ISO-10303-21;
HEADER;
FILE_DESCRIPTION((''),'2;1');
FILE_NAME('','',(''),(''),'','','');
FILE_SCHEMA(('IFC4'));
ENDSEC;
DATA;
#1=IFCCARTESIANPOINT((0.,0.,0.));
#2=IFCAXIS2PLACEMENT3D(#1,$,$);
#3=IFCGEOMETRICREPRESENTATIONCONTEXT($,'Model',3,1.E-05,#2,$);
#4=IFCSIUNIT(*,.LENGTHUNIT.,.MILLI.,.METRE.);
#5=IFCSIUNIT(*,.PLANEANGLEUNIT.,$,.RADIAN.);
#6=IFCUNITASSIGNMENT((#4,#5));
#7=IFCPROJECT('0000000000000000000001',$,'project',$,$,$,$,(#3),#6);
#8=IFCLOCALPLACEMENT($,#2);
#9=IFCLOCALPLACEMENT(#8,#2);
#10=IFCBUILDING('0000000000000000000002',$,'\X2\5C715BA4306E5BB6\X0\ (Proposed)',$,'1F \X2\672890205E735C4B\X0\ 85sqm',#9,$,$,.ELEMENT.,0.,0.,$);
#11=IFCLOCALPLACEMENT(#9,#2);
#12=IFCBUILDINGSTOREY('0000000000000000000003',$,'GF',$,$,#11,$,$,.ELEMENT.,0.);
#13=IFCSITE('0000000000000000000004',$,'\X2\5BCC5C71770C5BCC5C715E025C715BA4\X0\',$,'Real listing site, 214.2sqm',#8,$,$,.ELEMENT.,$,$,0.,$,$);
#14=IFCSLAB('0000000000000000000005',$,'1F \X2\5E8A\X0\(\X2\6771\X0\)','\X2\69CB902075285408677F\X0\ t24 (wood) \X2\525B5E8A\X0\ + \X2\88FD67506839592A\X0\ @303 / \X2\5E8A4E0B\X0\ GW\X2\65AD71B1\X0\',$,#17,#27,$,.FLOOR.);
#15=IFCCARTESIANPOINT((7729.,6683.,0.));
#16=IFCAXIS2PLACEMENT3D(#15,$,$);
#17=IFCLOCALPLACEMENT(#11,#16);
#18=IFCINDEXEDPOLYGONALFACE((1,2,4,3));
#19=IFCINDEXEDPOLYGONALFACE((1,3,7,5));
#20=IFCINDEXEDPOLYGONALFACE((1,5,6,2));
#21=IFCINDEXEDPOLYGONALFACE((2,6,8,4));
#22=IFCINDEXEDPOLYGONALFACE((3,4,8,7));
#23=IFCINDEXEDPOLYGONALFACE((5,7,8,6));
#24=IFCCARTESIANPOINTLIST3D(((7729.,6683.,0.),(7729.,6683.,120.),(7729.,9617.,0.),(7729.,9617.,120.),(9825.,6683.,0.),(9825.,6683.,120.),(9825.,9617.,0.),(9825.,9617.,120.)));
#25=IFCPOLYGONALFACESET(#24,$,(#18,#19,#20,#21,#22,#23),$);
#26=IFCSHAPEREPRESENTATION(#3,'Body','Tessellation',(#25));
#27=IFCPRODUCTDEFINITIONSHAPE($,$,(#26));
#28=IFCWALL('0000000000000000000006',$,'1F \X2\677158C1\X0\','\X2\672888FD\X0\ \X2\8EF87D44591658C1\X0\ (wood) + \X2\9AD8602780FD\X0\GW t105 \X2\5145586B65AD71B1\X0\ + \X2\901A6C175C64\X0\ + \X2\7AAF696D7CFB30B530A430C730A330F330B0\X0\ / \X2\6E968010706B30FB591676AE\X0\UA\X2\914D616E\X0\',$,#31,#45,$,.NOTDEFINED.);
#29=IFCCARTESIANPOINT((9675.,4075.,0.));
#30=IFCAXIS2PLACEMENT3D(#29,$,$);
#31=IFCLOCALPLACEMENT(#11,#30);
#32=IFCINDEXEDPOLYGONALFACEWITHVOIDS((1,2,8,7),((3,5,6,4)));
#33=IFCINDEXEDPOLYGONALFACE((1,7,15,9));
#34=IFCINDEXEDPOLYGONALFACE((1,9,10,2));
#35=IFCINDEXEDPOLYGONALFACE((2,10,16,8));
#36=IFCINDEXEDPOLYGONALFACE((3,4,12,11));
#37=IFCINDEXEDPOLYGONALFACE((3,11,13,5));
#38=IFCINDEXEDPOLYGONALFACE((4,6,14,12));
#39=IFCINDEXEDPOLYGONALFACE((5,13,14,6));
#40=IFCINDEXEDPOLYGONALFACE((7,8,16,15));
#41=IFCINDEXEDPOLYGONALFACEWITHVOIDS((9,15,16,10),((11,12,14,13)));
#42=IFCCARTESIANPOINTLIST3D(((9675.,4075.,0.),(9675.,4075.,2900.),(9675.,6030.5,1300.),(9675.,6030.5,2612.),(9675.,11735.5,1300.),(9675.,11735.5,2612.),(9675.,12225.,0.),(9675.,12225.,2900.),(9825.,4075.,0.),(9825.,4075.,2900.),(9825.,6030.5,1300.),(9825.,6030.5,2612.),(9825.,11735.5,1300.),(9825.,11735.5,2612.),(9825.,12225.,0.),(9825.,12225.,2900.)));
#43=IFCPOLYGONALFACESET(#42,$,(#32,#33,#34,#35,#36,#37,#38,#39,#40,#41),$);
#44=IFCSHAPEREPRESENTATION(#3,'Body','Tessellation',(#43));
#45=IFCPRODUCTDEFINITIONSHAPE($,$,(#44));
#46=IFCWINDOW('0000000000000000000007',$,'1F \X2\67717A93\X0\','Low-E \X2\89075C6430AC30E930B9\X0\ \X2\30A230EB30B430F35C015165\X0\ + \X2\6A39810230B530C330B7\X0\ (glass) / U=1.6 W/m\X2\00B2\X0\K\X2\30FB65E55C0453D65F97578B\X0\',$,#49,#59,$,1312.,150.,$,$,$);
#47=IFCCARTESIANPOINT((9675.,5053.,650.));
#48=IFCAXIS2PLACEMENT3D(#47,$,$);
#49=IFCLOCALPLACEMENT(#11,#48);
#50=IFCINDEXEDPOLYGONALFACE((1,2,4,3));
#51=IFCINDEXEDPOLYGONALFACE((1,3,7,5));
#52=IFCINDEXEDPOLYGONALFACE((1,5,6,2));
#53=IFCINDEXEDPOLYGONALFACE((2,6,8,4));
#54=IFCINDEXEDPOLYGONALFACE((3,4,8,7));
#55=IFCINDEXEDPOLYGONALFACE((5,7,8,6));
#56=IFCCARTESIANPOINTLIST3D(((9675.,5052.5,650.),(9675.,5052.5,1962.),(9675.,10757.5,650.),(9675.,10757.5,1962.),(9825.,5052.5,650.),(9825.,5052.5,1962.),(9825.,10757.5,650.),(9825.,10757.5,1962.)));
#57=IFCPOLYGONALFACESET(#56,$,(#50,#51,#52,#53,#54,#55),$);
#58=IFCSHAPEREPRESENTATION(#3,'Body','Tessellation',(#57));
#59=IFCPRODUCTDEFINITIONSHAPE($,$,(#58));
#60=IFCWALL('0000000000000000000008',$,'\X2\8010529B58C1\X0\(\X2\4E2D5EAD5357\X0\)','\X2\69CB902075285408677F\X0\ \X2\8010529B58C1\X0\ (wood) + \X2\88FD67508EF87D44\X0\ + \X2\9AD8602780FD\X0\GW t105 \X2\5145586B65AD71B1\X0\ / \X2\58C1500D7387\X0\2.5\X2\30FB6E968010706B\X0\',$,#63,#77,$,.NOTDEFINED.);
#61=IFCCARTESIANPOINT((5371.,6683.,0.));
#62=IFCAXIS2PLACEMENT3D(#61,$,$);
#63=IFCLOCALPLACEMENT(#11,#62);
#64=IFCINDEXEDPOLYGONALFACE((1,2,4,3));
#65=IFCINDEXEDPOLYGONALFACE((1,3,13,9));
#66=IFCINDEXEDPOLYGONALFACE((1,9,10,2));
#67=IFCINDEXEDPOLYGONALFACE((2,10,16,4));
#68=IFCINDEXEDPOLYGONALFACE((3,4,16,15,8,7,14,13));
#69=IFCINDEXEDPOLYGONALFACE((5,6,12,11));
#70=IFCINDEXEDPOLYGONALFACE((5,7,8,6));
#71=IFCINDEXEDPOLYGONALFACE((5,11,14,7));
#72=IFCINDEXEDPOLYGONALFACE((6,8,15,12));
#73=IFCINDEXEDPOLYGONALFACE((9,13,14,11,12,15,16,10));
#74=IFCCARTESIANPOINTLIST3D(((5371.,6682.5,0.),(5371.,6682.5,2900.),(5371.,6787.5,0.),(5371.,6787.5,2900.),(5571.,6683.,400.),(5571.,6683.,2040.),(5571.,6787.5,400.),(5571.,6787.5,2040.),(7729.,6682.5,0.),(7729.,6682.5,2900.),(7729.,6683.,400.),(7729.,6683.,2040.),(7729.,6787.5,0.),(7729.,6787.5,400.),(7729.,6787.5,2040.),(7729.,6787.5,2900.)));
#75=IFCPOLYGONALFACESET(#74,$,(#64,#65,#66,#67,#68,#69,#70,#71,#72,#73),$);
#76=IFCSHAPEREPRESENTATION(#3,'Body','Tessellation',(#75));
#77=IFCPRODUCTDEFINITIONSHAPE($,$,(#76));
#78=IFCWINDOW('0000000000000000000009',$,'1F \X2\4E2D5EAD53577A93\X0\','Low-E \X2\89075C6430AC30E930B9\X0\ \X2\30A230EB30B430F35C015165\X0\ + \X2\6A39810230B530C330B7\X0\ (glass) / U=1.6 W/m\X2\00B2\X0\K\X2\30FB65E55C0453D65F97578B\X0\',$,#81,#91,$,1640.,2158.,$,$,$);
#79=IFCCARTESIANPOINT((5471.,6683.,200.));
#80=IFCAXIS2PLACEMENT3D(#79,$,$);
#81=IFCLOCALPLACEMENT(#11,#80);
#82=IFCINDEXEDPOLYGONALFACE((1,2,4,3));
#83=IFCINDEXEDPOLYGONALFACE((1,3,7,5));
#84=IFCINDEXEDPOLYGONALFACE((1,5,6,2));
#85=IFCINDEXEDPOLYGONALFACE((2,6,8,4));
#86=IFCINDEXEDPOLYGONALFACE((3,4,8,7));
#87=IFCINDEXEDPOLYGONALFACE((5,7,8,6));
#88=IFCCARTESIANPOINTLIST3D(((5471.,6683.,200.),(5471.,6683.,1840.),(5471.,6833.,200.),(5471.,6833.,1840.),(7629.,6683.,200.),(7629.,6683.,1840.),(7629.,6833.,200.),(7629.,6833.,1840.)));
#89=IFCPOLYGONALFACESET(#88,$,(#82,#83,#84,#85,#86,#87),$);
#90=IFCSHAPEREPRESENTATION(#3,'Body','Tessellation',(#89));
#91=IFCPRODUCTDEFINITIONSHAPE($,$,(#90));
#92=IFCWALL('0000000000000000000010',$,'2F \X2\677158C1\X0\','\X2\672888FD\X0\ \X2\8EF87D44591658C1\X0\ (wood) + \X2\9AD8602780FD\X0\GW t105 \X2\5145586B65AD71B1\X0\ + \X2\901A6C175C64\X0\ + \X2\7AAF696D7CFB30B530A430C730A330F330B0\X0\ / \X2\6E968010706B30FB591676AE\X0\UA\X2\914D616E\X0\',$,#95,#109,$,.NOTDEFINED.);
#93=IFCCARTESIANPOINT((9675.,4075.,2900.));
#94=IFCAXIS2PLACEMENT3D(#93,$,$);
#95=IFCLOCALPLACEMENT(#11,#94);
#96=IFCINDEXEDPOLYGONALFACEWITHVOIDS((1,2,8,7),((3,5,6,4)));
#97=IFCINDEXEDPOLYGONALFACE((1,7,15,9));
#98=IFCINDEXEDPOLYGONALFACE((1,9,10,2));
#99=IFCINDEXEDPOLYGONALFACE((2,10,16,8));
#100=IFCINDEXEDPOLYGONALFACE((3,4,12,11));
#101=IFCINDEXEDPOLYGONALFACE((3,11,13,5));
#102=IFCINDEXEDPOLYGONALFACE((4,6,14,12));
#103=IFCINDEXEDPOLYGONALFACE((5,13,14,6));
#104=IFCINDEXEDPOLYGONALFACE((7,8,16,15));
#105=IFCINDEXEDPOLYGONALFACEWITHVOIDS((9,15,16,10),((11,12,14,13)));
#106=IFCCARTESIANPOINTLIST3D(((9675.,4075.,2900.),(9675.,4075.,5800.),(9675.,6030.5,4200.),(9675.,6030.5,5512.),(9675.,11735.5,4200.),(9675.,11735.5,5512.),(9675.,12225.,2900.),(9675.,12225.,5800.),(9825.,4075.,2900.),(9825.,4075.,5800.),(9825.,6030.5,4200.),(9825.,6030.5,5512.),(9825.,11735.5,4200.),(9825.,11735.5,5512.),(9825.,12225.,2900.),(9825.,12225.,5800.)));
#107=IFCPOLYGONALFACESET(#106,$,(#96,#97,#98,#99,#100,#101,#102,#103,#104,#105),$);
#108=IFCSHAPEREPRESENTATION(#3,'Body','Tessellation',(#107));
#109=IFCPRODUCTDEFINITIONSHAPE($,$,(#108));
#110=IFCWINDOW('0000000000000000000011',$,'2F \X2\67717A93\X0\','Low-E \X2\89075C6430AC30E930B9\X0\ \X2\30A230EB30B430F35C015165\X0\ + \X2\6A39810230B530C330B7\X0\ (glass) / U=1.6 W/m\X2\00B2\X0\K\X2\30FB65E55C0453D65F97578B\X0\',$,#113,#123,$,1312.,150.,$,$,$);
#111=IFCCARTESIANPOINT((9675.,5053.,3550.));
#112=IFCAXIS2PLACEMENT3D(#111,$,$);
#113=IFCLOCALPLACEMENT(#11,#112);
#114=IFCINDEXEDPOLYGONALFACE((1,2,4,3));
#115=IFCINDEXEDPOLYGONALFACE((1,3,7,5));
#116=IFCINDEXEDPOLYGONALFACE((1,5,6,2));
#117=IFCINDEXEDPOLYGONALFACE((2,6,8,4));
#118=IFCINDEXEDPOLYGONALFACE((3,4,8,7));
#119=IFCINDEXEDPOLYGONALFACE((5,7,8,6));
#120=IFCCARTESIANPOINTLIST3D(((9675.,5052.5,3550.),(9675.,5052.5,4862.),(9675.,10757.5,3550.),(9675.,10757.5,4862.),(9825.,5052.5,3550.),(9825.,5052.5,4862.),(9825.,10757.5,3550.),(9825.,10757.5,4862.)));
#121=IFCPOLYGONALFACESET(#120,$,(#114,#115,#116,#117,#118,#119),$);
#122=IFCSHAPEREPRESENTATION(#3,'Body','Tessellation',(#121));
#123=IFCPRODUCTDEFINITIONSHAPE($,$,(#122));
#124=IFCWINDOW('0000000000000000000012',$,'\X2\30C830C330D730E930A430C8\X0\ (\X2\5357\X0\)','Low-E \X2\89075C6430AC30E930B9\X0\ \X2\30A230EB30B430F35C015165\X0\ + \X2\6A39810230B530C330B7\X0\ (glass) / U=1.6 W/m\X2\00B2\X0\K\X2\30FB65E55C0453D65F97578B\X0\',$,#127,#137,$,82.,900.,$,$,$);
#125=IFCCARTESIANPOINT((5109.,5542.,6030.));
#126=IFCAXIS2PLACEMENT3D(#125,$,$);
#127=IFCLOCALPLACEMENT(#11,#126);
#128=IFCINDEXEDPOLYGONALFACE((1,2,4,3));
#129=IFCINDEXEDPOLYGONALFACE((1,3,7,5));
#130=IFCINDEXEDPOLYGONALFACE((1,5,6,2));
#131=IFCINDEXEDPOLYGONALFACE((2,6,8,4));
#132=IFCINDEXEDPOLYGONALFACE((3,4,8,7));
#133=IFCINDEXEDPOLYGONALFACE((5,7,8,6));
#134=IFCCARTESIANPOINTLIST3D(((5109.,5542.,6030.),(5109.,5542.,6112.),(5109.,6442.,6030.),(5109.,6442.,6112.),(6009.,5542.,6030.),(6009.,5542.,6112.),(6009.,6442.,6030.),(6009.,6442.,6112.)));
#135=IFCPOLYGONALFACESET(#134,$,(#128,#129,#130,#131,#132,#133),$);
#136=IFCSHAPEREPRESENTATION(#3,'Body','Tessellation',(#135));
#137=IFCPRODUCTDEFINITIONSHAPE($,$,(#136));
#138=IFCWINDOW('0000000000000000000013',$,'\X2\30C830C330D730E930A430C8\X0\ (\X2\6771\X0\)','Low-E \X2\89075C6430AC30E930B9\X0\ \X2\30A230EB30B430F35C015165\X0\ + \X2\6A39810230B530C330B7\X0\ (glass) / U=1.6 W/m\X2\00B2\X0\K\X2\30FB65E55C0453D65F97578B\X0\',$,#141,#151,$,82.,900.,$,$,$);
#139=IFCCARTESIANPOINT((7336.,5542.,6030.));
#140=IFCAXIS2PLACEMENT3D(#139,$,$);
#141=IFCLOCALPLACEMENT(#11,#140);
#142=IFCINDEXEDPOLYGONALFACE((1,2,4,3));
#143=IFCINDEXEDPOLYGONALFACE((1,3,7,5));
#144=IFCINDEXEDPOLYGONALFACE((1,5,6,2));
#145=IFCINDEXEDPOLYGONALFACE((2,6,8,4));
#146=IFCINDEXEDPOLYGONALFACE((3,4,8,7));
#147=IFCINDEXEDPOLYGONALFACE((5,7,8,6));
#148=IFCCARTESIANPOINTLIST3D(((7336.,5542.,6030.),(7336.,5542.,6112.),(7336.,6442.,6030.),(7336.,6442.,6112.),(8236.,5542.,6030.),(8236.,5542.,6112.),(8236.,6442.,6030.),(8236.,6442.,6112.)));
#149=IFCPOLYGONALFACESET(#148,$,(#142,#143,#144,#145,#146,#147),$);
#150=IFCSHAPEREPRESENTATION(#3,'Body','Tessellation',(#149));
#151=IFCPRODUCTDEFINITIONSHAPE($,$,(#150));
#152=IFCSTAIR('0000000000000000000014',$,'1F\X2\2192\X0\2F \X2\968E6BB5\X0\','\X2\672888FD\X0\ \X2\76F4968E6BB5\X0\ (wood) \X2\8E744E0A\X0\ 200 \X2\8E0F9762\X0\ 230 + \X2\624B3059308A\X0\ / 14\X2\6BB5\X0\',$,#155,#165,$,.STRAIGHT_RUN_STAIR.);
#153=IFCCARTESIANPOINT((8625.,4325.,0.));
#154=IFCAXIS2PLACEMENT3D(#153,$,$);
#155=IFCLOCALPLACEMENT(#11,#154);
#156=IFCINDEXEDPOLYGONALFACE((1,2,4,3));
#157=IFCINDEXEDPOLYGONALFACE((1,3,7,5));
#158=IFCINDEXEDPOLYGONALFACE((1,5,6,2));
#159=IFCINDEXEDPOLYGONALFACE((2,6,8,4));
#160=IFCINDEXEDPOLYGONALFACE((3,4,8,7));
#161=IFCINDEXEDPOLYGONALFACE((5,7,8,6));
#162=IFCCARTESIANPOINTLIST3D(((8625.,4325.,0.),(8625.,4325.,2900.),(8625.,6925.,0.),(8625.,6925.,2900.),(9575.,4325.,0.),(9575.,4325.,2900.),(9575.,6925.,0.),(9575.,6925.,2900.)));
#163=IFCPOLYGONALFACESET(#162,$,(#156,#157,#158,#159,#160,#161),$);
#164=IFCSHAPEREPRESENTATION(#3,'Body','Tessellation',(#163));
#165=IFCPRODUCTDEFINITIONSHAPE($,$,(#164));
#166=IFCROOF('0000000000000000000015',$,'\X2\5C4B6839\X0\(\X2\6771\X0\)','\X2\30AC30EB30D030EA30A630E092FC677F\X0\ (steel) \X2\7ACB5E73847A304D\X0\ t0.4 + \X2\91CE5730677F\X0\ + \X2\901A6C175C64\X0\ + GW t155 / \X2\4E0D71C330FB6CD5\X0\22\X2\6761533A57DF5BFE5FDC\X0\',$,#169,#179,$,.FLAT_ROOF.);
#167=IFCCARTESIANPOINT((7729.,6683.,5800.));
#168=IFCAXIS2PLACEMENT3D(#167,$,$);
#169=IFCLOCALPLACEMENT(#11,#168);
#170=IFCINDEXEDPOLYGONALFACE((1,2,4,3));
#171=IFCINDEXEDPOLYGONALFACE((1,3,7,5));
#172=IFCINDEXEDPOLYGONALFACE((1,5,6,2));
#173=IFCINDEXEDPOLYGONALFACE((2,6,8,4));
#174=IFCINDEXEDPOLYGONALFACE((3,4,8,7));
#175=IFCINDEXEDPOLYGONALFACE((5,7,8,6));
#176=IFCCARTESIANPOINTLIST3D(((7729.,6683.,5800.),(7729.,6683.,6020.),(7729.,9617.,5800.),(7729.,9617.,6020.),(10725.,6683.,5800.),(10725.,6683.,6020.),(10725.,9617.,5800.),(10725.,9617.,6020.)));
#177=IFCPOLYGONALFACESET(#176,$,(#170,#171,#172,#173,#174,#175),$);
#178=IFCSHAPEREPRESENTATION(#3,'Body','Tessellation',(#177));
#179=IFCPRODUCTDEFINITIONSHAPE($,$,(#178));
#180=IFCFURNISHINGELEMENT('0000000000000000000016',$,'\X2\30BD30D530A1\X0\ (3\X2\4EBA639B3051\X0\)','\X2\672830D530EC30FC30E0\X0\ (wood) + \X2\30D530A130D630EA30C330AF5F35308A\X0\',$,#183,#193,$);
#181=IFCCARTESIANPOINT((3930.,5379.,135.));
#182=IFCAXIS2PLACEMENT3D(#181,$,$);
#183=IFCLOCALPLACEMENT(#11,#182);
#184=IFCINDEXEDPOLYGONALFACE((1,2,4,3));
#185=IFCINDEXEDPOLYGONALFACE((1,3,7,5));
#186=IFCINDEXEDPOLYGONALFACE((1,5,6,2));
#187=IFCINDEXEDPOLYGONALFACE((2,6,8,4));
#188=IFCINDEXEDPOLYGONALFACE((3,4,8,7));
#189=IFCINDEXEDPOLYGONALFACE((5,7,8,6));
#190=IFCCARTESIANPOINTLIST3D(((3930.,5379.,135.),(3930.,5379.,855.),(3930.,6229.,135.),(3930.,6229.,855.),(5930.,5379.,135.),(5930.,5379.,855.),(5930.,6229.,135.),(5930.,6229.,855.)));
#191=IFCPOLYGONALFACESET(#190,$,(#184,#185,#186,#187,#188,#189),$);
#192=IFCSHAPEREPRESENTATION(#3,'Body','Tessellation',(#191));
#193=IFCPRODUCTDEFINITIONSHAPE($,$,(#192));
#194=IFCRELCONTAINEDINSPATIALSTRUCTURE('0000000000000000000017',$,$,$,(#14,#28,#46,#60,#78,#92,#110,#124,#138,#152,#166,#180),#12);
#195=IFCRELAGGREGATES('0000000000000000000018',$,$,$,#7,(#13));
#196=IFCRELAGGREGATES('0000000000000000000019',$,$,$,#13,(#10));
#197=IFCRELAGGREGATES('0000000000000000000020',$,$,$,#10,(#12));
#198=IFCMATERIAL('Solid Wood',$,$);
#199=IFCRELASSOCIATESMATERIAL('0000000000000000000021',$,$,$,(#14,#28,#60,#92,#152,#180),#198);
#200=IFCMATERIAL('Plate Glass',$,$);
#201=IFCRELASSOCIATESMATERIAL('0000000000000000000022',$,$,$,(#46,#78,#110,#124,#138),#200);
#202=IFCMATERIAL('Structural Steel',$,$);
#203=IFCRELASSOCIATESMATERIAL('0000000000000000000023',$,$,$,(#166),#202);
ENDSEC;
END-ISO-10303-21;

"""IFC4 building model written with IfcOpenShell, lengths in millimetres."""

from ifc_helpers import new_model, si_unit, frame, frame_2d, origin, place, context, project, spatial, rectangle, extrude, material, element, fill, save


model = new_model("IFC4")

# Units and contexts
model_context = context("Model", 3, precision=1e-05, world=origin())
ifc_project = project(units=[si_unit("LENGTHUNIT", "METRE", prefix="MILLI"), si_unit("PLANEANGLEUNIT", "RADIAN")], contexts=[model_context])

# Site, building, storey
site_placement = place(None, origin())
site = spatial("IfcSite", under=ifc_project, at=site_placement, Name="富山県富山市山室", ObjectType="Real listing site, 214.2sqm", CompositionType="ELEMENT", RefElevation=0.0)
building_placement = place(site_placement, origin())
building = spatial("IfcBuilding", under=site, at=building_placement, Name="山室の家 (Proposed)", ObjectType="1F 木造平屋 85sqm", CompositionType="ELEMENT", ElevationOfRefHeight=0.0, ElevationOfTerrain=0.0)
storey_placement = place(building_placement, origin())
storey = spatial("IfcBuildingStorey", under=building, at=storey_placement, Name="GF", CompositionType="ELEMENT", Elevation=0.0)

# Slab
ifc_material_1 = material(Name="Solid Wood")
slab_placement = place(storey_placement, frame((7729.0, 6683.0, 0.0)))
element("IfcSlab", 1, at=slab_placement, inside=storey, material=ifc_material_1, Name="1F 床(東)", Description="構造用合板 t24 (wood) 剛床 + 製材根太 @303 / 床下 GW断熱", PredefinedType="FLOOR", context=model_context, shape_type="SweptSolid", body=[
    extrude(rectangle(XDim=2096.0, YDim=2934.0, at=frame_2d((1048.0, 1467.0))), frame((7729.0, 6683.0, 0.0)), (0.0, 0.0, 1.0), 120.0),
])

# Walls, openings, windows
wall_1_placement = place(storey_placement, frame((9675.0, 4075.0, 0.0)))
wall_1 = element("IfcWall", 2, at=wall_1_placement, inside=storey, material=ifc_material_1, Name="1F 東壁", Description="木製 軸組外壁 (wood) + 高性能GW t105 充填断熱 + 通気層 + 窯業系サイディング / 準耐火・外皮UA配慮", PredefinedType="NOTDEFINED", context=model_context, shape_type="SweptSolid", body=[
    extrude(rectangle(XDim=150.0, YDim=8150.0, at=frame_2d((75.0, 4075.0))), frame((9675.0, 4075.0, 0.0)), (0.0, 0.0, 1.0), 2900.0),
])
opening_1_placement = place(storey_placement, frame((9675.0, 5053.0, 650.0)))
opening_1 = element("IfcOpeningElement", 3, at=opening_1_placement, cuts=wall_1, PredefinedType="NOTDEFINED", context=model_context, shape_type="SweptSolid", body=[
    extrude(rectangle(XDim=150.0, YDim=5705.0, at=frame_2d((75.0, 2852.0))), frame((9675.0, 5053.0, 650.0)), (0.0, 0.0, 1.0), 1312.0),
])
ifc_material_2 = material(Name="Plate Glass")
window_1_placement = place(storey_placement, frame((9675.0, 5053.0, 650.0)))
window_1 = element("IfcWindow", 4, at=window_1_placement, inside=storey, material=ifc_material_2, Name="1F 東窓", Description="Low-E 複層ガラス アルゴン封入 + 樹脂サッシ (glass) / U=1.6 W/m²K・日射取得型", OverallHeight=1312.0, OverallWidth=150.0, context=model_context, shape_type="SweptSolid", body=[
    extrude(rectangle(XDim=150.0, YDim=5705.0, at=frame_2d((75.0, 2852.0))), frame((9675.0, 5053.0, 650.0)), (0.0, 0.0, 1.0), 1312.0),
])
fill(opening_1, window_1)
wall_2_placement = place(storey_placement, frame((5371.0, 6683.0, 0.0)))
wall_2 = element("IfcWall", 5, at=wall_2_placement, inside=storey, material=ifc_material_1, Name="耐力壁(中庭南)", Description="構造用合板 耐力壁 (wood) + 製材軸組 + 高性能GW t105 充填断熱 / 壁倍率2.5・準耐火", PredefinedType="NOTDEFINED", context=model_context, shape_type="SweptSolid", body=[
    extrude(rectangle(XDim=2358.0, YDim=105.0, at=frame_2d((1179.0, 52.0))), frame((5371.0, 6683.0, 0.0)), (0.0, 0.0, 1.0), 2900.0),
])
opening_2_placement = place(storey_placement, frame((5471.0, 6683.0, 200.0)))
opening_2 = element("IfcOpeningElement", 6, at=opening_2_placement, cuts=wall_2, PredefinedType="NOTDEFINED", context=model_context, shape_type="SweptSolid", body=[
    extrude(rectangle(XDim=2158.0, YDim=150.0, at=frame_2d((1079.0, 75.0))), frame((5471.0, 6683.0, 200.0)), (0.0, 0.0, 1.0), 1640.0),
])
window_2_placement = place(storey_placement, frame((5471.0, 6683.0, 200.0)))
window_2 = element("IfcWindow", 7, at=window_2_placement, inside=storey, material=ifc_material_2, Name="1F 中庭南窓", Description="Low-E 複層ガラス アルゴン封入 + 樹脂サッシ (glass) / U=1.6 W/m²K・日射取得型", OverallHeight=1640.0, OverallWidth=2158.0, context=model_context, shape_type="SweptSolid", body=[
    extrude(rectangle(XDim=2158.0, YDim=150.0, at=frame_2d((1079.0, 75.0))), frame((5471.0, 6683.0, 200.0)), (0.0, 0.0, 1.0), 1640.0),
])
fill(opening_2, window_2)

# Wall, opening, window
wall_3_placement = place(storey_placement, frame((9675.0, 4075.0, 2900.0)))
wall_3 = element("IfcWall", 8, at=wall_3_placement, inside=storey, material=ifc_material_1, Name="2F 東壁", Description="木製 軸組外壁 (wood) + 高性能GW t105 充填断熱 + 通気層 + 窯業系サイディング / 準耐火・外皮UA配慮", PredefinedType="NOTDEFINED", context=model_context, shape_type="SweptSolid", body=[
    extrude(rectangle(XDim=150.0, YDim=8150.0, at=frame_2d((75.0, 4075.0))), frame((9675.0, 4075.0, 2900.0)), (0.0, 0.0, 1.0), 2900.0),
])
opening_3_placement = place(storey_placement, frame((9675.0, 5053.0, 3550.0)))
opening_3 = element("IfcOpeningElement", 9, at=opening_3_placement, cuts=wall_3, PredefinedType="NOTDEFINED", context=model_context, shape_type="SweptSolid", body=[
    extrude(rectangle(XDim=150.0, YDim=5705.0, at=frame_2d((75.0, 2852.0))), frame((9675.0, 5053.0, 3550.0)), (0.0, 0.0, 1.0), 1312.0),
])
window_3_placement = place(storey_placement, frame((9675.0, 5053.0, 3550.0)))
window_3 = element("IfcWindow", 10, at=window_3_placement, inside=storey, material=ifc_material_2, Name="2F 東窓", Description="Low-E 複層ガラス アルゴン封入 + 樹脂サッシ (glass) / U=1.6 W/m²K・日射取得型", OverallHeight=1312.0, OverallWidth=150.0, context=model_context, shape_type="SweptSolid", body=[
    extrude(rectangle(XDim=150.0, YDim=5705.0, at=frame_2d((75.0, 2852.0))), frame((9675.0, 5053.0, 3550.0)), (0.0, 0.0, 1.0), 1312.0),
])
fill(opening_3, window_3)

# Windows
window_4_placement = place(storey_placement, frame((5109.0, 5542.0, 6030.0)))
element("IfcWindow", 11, at=window_4_placement, inside=storey, material=ifc_material_2, Name="トップライト (南)", Description="Low-E 複層ガラス アルゴン封入 + 樹脂サッシ (glass) / U=1.6 W/m²K・日射取得型", OverallHeight=82.0, OverallWidth=900.0, context=model_context, shape_type="SweptSolid", body=[
    extrude(rectangle(XDim=900.0, YDim=900.0, at=frame_2d((450.0, 450.0))), frame((5109.0, 5542.0, 6030.0)), (0.0, 0.0, 1.0), 82.0),
])
window_5_placement = place(storey_placement, frame((7336.0, 5542.0, 6030.0)))
element("IfcWindow", 12, at=window_5_placement, inside=storey, material=ifc_material_2, Name="トップライト (東)", Description="Low-E 複層ガラス アルゴン封入 + 樹脂サッシ (glass) / U=1.6 W/m²K・日射取得型", OverallHeight=82.0, OverallWidth=900.0, context=model_context, shape_type="SweptSolid", body=[
    extrude(rectangle(XDim=900.0, YDim=900.0, at=frame_2d((450.0, 450.0))), frame((7336.0, 5542.0, 6030.0)), (0.0, 0.0, 1.0), 82.0),
])

# Stair
stair_placement = place(storey_placement, frame((8625.0, 4325.0, 0.0)))
element("IfcStair", 13, at=stair_placement, inside=storey, material=ifc_material_1, Name="1F→2F 階段", Description="木製 直階段 (wood) 蹴上 200 踏面 230 + 手すり / 14段", PredefinedType="STRAIGHT_RUN_STAIR", context=model_context, shape_type="SweptSolid", body=[
    extrude(rectangle(XDim=950.0, YDim=2600.0, at=frame_2d((475.0, 1300.0))), frame((8625.0, 4325.0, 0.0)), (0.0, 0.0, 1.0), 2900.0),
])

# Roof
ifc_material_3 = material(Name="Structural Steel")
roof_placement = place(storey_placement, frame((7729.0, 6683.0, 5800.0)))
element("IfcRoof", 14, at=roof_placement, inside=storey, material=ifc_material_3, Name="屋根(東)", Description="ガルバリウム鋼板 (steel) 立平葺き t0.4 + 野地板 + 通気層 + GW t155 / 不燃・法22条区域対応", PredefinedType="FLAT_ROOF", context=model_context, shape_type="SweptSolid", body=[
    extrude(rectangle(XDim=2996.0, YDim=2934.0, at=frame_2d((1498.0, 1467.0))), frame((7729.0, 6683.0, 5800.0)), (0.0, 0.0, 1.0), 220.0),
])

# Furnishing element
furnishing_1_placement = place(storey_placement, frame((3930.0, 5379.0, 135.0)))
element("IfcFurnishingElement", 15, at=furnishing_1_placement, inside=storey, material=ifc_material_1, Name="ソファ (3人掛け)", Description="木フレーム (wood) + ファブリック張り", context=model_context, shape_type="SweptSolid", body=[
    extrude(rectangle(XDim=2000.0, YDim=850.0, at=frame_2d((1000.0, 425.0))), frame((3930.0, 5379.0, 135.0)), (0.0, 0.0, 1.0), 720.0),
])

save(model, "model.ifc")
